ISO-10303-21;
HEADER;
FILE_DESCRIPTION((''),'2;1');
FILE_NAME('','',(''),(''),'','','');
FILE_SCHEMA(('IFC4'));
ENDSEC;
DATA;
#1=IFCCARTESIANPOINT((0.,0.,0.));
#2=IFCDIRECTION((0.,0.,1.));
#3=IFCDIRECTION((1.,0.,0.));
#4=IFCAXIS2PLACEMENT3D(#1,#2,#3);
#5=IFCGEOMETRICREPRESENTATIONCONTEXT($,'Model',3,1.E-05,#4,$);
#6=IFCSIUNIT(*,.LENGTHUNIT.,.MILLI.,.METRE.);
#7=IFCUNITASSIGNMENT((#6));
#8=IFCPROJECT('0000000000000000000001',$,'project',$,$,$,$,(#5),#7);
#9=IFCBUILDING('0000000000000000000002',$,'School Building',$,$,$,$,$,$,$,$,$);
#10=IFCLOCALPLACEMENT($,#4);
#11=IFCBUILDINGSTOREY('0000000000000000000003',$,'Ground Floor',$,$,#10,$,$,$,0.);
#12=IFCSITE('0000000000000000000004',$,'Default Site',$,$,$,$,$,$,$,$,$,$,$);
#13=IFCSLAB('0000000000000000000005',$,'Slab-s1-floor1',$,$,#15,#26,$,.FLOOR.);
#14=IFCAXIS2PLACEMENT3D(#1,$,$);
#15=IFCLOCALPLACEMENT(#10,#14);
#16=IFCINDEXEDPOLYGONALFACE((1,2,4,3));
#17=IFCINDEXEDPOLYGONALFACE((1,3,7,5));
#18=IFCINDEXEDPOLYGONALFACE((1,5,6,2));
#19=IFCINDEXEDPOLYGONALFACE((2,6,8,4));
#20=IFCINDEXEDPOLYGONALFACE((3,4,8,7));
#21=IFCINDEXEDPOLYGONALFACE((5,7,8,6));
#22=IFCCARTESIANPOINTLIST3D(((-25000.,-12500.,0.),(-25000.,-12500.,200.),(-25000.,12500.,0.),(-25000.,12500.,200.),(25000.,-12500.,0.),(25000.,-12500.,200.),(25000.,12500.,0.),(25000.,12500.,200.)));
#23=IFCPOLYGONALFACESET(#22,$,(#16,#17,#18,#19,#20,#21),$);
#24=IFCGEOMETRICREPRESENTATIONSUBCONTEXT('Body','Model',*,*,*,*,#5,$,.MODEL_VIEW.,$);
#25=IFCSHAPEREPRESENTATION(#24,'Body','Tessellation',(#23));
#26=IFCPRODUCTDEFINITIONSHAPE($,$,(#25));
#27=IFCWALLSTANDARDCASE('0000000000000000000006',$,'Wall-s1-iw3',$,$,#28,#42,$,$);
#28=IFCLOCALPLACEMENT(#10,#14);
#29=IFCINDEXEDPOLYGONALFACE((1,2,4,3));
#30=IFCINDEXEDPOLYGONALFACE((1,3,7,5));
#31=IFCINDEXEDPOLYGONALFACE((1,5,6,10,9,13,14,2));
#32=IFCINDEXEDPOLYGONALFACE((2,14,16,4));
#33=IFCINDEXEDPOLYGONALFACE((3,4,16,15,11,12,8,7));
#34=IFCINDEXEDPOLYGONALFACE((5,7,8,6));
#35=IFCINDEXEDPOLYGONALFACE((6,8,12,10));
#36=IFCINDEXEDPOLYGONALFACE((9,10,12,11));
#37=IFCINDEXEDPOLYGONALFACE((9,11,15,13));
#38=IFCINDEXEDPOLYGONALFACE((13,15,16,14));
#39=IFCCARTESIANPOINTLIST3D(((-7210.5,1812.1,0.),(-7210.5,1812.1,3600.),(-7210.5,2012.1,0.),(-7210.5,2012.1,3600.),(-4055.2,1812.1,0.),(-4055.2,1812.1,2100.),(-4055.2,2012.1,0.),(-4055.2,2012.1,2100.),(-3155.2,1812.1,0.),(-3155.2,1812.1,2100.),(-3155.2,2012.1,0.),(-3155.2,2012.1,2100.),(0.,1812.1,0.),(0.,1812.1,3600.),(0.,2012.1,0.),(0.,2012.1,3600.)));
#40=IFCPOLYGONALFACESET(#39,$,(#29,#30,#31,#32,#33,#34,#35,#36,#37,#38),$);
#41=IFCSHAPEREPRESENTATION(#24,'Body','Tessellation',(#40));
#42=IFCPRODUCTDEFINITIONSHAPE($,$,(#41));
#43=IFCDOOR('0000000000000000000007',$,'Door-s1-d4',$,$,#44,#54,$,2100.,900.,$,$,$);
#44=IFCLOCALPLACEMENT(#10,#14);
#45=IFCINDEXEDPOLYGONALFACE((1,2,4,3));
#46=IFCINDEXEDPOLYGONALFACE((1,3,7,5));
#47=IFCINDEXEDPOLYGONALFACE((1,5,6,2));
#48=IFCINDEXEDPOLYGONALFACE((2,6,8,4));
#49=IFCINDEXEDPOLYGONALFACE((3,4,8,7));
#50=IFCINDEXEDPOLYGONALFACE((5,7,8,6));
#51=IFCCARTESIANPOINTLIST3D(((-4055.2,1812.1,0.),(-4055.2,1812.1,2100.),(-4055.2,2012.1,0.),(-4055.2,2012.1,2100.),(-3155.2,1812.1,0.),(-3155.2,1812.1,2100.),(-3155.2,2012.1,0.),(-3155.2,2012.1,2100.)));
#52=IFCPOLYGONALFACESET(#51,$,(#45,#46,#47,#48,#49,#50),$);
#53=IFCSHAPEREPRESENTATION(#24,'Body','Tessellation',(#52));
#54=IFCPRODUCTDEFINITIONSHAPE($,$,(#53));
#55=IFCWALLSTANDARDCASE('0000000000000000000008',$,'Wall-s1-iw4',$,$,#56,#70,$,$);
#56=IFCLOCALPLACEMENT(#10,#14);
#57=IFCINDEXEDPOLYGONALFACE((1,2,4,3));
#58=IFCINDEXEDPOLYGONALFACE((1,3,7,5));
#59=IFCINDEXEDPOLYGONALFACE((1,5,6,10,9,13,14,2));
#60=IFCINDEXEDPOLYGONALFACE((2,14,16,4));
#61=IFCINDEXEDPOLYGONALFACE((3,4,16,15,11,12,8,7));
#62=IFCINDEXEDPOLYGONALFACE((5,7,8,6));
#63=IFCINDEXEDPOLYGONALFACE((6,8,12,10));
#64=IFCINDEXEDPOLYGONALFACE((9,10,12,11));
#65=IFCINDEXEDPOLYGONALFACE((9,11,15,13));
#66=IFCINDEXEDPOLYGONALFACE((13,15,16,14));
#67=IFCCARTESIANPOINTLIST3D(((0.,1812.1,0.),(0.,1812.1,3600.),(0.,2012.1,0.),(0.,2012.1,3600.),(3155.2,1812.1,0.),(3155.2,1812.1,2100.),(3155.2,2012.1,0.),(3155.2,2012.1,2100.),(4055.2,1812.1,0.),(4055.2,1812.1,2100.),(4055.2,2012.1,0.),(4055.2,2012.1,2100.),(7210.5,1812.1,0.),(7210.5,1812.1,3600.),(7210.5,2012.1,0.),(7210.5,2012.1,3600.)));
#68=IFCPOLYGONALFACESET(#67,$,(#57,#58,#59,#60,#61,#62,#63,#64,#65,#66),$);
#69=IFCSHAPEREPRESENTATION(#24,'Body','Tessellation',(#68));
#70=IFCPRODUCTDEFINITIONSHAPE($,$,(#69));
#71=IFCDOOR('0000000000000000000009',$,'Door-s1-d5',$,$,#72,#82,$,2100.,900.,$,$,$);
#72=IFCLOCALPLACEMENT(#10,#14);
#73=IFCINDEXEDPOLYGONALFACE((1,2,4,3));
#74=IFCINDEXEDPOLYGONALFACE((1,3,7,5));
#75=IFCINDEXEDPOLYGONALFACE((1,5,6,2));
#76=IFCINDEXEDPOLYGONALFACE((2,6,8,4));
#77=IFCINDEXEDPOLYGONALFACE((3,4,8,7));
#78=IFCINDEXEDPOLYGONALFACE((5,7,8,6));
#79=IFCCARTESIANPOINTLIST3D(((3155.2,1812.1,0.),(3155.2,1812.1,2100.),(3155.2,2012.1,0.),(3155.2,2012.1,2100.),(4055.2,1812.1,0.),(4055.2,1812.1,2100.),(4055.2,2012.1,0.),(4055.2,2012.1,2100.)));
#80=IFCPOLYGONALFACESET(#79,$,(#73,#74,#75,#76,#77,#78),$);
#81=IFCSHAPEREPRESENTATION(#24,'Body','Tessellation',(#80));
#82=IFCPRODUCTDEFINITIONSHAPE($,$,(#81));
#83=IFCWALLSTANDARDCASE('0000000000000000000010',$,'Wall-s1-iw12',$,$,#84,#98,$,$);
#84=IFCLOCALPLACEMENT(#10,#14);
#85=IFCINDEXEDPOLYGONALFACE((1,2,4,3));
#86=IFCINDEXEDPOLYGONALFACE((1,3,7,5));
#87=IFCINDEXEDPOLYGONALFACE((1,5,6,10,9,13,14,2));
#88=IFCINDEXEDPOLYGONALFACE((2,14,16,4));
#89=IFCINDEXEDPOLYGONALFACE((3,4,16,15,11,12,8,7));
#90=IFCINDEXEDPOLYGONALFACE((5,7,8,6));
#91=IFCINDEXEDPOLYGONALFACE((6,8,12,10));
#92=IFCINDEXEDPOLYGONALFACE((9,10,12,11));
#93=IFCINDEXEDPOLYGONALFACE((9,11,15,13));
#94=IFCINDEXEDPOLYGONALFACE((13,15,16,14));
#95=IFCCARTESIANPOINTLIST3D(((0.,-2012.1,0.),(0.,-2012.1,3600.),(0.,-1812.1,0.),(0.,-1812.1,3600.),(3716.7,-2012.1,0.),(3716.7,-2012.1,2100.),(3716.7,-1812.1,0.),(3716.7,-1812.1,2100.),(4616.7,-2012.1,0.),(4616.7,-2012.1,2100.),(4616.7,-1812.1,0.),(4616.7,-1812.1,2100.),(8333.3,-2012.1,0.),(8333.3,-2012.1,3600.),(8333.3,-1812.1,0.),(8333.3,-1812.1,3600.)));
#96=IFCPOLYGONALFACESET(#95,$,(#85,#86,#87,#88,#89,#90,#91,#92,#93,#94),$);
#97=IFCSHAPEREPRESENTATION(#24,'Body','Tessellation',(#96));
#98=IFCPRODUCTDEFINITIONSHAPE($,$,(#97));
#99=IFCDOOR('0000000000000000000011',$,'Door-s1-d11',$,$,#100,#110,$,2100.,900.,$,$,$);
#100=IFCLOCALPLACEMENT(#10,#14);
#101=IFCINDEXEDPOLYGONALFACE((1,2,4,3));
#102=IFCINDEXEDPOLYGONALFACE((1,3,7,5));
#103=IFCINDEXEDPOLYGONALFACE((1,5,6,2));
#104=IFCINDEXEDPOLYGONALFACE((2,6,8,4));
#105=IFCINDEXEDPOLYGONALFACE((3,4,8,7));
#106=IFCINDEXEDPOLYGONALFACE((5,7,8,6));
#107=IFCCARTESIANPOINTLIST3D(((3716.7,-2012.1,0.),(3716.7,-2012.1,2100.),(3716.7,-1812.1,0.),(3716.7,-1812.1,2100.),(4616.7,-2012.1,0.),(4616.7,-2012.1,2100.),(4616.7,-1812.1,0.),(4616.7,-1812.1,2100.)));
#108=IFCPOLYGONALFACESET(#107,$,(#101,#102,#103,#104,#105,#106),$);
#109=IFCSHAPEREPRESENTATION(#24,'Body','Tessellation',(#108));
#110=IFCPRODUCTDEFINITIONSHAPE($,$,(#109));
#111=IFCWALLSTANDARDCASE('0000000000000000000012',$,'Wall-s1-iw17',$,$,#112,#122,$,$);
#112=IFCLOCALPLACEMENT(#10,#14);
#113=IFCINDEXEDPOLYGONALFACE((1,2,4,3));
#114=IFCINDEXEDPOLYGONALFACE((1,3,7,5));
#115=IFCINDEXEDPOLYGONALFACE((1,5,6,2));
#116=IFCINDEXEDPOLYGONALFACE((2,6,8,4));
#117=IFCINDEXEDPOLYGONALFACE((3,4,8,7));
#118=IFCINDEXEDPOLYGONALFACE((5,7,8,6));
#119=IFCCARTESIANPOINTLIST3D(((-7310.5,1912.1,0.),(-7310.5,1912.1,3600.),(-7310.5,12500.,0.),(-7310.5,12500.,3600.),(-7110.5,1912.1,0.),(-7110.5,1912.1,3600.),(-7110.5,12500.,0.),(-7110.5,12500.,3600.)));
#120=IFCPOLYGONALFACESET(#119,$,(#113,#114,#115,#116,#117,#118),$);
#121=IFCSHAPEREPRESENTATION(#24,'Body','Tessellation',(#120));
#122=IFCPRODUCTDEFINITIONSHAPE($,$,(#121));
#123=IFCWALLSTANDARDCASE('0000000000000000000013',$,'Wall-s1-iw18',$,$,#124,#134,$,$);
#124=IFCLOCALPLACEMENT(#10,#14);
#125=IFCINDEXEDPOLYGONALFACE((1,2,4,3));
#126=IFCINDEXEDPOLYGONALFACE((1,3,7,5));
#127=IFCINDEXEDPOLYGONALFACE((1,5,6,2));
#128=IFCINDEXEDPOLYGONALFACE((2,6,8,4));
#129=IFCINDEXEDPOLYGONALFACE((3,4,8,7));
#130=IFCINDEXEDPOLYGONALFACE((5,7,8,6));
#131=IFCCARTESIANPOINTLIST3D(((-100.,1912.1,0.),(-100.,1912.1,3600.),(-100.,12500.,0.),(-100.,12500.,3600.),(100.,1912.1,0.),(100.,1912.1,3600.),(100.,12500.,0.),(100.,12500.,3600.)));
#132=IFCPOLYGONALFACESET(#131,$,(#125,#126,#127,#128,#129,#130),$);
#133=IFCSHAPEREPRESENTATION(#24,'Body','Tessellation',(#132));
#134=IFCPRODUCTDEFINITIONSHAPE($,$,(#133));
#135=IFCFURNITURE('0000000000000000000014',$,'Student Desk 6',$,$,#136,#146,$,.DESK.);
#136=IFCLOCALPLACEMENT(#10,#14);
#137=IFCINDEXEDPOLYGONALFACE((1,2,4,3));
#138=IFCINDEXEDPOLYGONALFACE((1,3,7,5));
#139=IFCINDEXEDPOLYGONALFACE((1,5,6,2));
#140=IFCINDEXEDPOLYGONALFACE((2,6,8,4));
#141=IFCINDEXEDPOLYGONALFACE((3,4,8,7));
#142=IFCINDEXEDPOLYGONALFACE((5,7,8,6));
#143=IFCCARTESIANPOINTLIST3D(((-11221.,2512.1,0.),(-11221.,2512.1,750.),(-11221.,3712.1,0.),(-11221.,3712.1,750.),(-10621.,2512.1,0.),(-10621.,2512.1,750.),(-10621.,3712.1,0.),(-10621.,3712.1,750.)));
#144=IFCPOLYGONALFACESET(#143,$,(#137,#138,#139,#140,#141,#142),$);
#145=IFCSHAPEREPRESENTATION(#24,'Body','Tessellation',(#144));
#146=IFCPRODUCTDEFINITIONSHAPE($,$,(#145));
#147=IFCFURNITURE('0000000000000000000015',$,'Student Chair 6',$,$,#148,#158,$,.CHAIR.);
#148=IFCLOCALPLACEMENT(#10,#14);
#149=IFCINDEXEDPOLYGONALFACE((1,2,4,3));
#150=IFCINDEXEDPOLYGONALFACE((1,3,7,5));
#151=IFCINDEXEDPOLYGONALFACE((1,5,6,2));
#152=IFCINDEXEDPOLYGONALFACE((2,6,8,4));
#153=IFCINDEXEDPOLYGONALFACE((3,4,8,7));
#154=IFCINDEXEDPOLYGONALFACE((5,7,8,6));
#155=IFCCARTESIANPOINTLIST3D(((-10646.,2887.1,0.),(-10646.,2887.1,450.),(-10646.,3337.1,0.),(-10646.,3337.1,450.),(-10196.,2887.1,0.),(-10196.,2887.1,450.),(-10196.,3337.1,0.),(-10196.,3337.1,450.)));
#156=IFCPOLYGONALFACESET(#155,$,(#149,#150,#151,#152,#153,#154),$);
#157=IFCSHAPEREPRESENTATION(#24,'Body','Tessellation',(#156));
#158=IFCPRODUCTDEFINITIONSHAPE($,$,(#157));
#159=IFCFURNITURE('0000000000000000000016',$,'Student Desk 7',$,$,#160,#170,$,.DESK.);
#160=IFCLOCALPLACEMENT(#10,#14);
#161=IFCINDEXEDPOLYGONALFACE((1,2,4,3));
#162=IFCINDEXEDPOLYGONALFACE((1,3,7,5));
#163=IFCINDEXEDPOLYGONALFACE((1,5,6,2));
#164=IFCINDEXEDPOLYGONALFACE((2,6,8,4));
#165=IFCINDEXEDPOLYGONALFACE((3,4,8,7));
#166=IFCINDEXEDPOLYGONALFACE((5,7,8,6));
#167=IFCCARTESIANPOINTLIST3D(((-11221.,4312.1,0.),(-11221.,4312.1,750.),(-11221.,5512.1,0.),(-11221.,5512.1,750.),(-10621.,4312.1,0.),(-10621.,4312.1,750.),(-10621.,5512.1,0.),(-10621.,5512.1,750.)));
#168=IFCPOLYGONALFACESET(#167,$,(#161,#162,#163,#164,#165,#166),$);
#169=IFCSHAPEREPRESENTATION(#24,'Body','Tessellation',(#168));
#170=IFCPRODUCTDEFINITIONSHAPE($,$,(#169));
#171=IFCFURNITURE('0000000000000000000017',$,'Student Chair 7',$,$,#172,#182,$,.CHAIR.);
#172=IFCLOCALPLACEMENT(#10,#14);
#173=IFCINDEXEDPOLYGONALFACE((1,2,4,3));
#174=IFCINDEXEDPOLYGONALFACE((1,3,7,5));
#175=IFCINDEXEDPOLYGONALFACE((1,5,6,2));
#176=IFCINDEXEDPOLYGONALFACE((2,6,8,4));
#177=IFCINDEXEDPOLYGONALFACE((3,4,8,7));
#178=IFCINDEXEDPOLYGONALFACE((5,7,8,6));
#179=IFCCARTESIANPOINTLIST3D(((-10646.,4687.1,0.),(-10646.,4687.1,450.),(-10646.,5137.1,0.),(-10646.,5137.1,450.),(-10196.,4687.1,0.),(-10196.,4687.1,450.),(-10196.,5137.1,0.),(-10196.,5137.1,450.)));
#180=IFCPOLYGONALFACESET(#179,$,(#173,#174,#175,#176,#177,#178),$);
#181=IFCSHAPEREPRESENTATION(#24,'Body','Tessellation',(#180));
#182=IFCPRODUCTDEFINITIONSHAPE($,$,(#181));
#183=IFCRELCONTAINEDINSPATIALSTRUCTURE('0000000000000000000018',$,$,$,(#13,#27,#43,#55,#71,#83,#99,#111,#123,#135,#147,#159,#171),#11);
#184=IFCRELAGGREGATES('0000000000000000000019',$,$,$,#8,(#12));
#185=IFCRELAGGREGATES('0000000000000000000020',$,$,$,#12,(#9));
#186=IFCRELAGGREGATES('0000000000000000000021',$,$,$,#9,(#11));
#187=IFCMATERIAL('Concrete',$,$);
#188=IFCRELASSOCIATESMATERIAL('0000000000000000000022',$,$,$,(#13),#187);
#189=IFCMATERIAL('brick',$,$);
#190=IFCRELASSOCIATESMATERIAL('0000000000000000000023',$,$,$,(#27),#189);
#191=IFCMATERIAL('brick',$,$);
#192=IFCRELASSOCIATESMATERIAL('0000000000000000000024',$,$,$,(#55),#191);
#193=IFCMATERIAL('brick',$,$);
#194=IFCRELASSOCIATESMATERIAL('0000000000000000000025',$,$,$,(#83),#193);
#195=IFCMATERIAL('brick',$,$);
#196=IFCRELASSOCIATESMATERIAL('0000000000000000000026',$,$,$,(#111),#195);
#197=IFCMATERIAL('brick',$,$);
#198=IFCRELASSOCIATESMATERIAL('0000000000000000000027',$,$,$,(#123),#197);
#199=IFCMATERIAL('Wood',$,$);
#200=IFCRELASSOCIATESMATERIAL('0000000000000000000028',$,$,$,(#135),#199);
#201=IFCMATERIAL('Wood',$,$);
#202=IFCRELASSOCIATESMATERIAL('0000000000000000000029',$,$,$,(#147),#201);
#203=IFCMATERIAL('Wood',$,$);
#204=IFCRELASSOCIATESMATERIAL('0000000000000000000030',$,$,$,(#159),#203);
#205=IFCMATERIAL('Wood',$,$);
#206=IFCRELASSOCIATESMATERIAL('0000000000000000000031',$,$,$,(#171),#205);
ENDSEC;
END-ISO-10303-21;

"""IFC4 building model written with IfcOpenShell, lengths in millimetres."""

from ifc_helpers import new_model, si_unit, frame, frame_2d, origin_with_axes, origin_2d, place, context, subcontext, project, spatial, polyline, rectangle, outline, extrude, material, element, fill, save


model = new_model("IFC4")

# Units and contexts
model_context = context("Model", 3, precision=1e-05, world=origin_with_axes())
body_context = subcontext(model_context, "Body", "Model", "MODEL_VIEW")
ifc_project = project(units=[si_unit("LENGTHUNIT", "METRE", prefix="MILLI")], contexts=[model_context])

# Site, building, storey
site = spatial("IfcSite", under=ifc_project, Name="Default Site")
building = spatial("IfcBuilding", under=site, Name="School Building")
storey_placement = place(None, origin_with_axes())
storey = spatial("IfcBuildingStorey", under=building, at=storey_placement, Name="Ground Floor", Elevation=0.0)

# Slab
ifc_material_1 = material(Name="Concrete")
slab_1_placement = place(storey_placement, origin_with_axes())
element("IfcSlab", 1, at=slab_1_placement, inside=storey, material=ifc_material_1, Name="Slab-s1-floor1", PredefinedType="FLOOR", context=body_context, shape_type="SweptSolid", body=[
    extrude(outline(polyline([(-25000.0, -12500.0), (25000.0, -12500.0), (25000.0, 12500.0), (-25000.0, 12500.0), (-25000.0, -12500.0)])), origin_with_axes(), (0.0, 0.0, 1.0), 200.0),
])

# Walls, openings, doors
ifc_material_2 = material(Name="brick")
wall_1_placement = place(storey_placement, frame((-7210.5, 1912.1, 0.0), z_axis=(0.0, 0.0, 1.0), x_axis=(1.0, 0.0, 0.0)))
wall_1 = element("IfcWallStandardCase", 2, at=wall_1_placement, inside=storey, material=ifc_material_2, Name="Wall-s1-iw3", context=body_context, shape_type="SweptSolid", body=[
    extrude(rectangle(XDim=7210.5, YDim=200.0, at=frame_2d((3605.2, 0.0))), origin_with_axes(), (0.0, 0.0, 1.0), 3600.0),
])
opening_1_placement = place(wall_1_placement, frame((3155.2, 0.0, 0.0), z_axis=(0.0, 0.0, 1.0), x_axis=(1.0, 0.0, 0.0)))
opening_1 = element("IfcOpeningElement", 3, at=opening_1_placement, cuts=wall_1, context=body_context, shape_type="SweptSolid", body=[
    extrude(rectangle(XDim=900.0, YDim=400.0, at=frame_2d((450.0, 0.0))), origin_with_axes(), (0.0, 0.0, 1.0), 2100.0),
])
door_1_placement = place(storey_placement, frame((-4055.2, 1912.1, 0.0), z_axis=(0.0, 0.0, 1.0), x_axis=(1.0, 0.0, 0.0)))
door_1 = element("IfcDoor", 4, at=door_1_placement, inside=storey, Name="Door-s1-d4", OverallHeight=2100.0, OverallWidth=900.0, context=body_context, shape_type="SweptSolid", body=[
    extrude(rectangle(XDim=900.0, YDim=200.0, at=frame_2d((450.0, 0.0))), origin_with_axes(), (0.0, 0.0, 1.0), 2100.0),
])
fill(opening_1, door_1)
ifc_material_3 = material(Name="brick")
wall_2_placement = place(storey_placement, frame((0.0, 1912.1, 0.0), z_axis=(0.0, 0.0, 1.0), x_axis=(1.0, 0.0, 0.0)))
wall_2 = element("IfcWallStandardCase", 5, at=wall_2_placement, inside=storey, material=ifc_material_3, Name="Wall-s1-iw4", context=body_context, shape_type="SweptSolid", body=[
    extrude(rectangle(XDim=7210.5, YDim=200.0, at=frame_2d((3605.2, 0.0))), origin_with_axes(), (0.0, 0.0, 1.0), 3600.0),
])
opening_2_placement = place(wall_2_placement, frame((3155.2, 0.0, 0.0), z_axis=(0.0, 0.0, 1.0), x_axis=(1.0, 0.0, 0.0)))
opening_2 = element("IfcOpeningElement", 6, at=opening_2_placement, cuts=wall_2, context=body_context, shape_type="SweptSolid", body=[
    extrude(rectangle(XDim=900.0, YDim=400.0, at=frame_2d((450.0, 0.0))), origin_with_axes(), (0.0, 0.0, 1.0), 2100.0),
])
door_2_placement = place(storey_placement, frame((3155.2, 1912.1, 0.0), z_axis=(0.0, 0.0, 1.0), x_axis=(1.0, 0.0, 0.0)))
door_2 = element("IfcDoor", 7, at=door_2_placement, inside=storey, Name="Door-s1-d5", OverallHeight=2100.0, OverallWidth=900.0, context=body_context, shape_type="SweptSolid", body=[
    extrude(rectangle(XDim=900.0, YDim=200.0, at=frame_2d((450.0, 0.0))), origin_with_axes(), (0.0, 0.0, 1.0), 2100.0),
])
fill(opening_2, door_2)
ifc_material_4 = material(Name="brick")
wall_3_placement = place(storey_placement, frame((0.0, -1912.1, 0.0), z_axis=(0.0, 0.0, 1.0), x_axis=(1.0, 0.0, 0.0)))
wall_3 = element("IfcWallStandardCase", 8, at=wall_3_placement, inside=storey, material=ifc_material_4, Name="Wall-s1-iw12", context=body_context, shape_type="SweptSolid", body=[
    extrude(rectangle(XDim=8333.3, YDim=200.0, at=frame_2d((4166.7, 0.0))), origin_with_axes(), (0.0, 0.0, 1.0), 3600.0),
])
opening_3_placement = place(wall_3_placement, frame((3716.7, 0.0, 0.0), z_axis=(0.0, 0.0, 1.0), x_axis=(1.0, 0.0, 0.0)))
opening_3 = element("IfcOpeningElement", 9, at=opening_3_placement, cuts=wall_3, context=body_context, shape_type="SweptSolid", body=[
    extrude(rectangle(XDim=900.0, YDim=400.0, at=frame_2d((450.0, 0.0))), origin_with_axes(), (0.0, 0.0, 1.0), 2100.0),
])
door_3_placement = place(storey_placement, frame((3716.7, -1912.1, 0.0), z_axis=(0.0, 0.0, 1.0), x_axis=(1.0, 0.0, 0.0)))
door_3 = element("IfcDoor", 10, at=door_3_placement, inside=storey, Name="Door-s1-d11", OverallHeight=2100.0, OverallWidth=900.0, context=body_context, shape_type="SweptSolid", body=[
    extrude(rectangle(XDim=900.0, YDim=200.0, at=frame_2d((450.0, 0.0))), origin_with_axes(), (0.0, 0.0, 1.0), 2100.0),
])
fill(opening_3, door_3)

# Walls
ifc_material_5 = material(Name="brick")
wall_4_placement = place(storey_placement, frame((-7210.5, 1912.1, 0.0), z_axis=(0.0, 0.0, 1.0), x_axis=(0.0, 1.0, 0.0)))
element("IfcWallStandardCase", 11, at=wall_4_placement, inside=storey, material=ifc_material_5, Name="Wall-s1-iw17", context=body_context, shape_type="SweptSolid", body=[
    extrude(rectangle(XDim=10587.9, YDim=200.0, at=frame_2d((5293.9, 0.0))), origin_with_axes(), (0.0, 0.0, 1.0), 3600.0),
])
ifc_material_6 = material(Name="brick")
wall_5_placement = place(storey_placement, frame((0.0, 1912.1, 0.0), z_axis=(0.0, 0.0, 1.0), x_axis=(0.0, 1.0, 0.0)))
element("IfcWallStandardCase", 12, at=wall_5_placement, inside=storey, material=ifc_material_6, Name="Wall-s1-iw18", context=body_context, shape_type="SweptSolid", body=[
    extrude(rectangle(XDim=10587.9, YDim=200.0, at=frame_2d((5293.9, 0.0))), origin_with_axes(), (0.0, 0.0, 1.0), 3600.0),
])

# Furniture
ifc_material_7 = material(Name="Wood")
furniture_1_placement = place(storey_placement, frame((-10921.0, 3112.1, 0.0), z_axis=(0.0, 0.0, 1.0), x_axis=(0.0, 1.0, 0.0)))
element("IfcFurniture", 13, at=furniture_1_placement, inside=storey, material=ifc_material_7, Name="Student Desk 6", PredefinedType="DESK", context=body_context, shape_type="SweptSolid", body=[
    extrude(rectangle(XDim=1200.0, YDim=600.0, at=origin_2d()), origin_with_axes(), (0.0, 0.0, 1.0), 750.0),
])
ifc_material_8 = material(Name="Wood")
furniture_2_placement = place(storey_placement, frame((-10421.0, 3112.1, 0.0), z_axis=(0.0, 0.0, 1.0), x_axis=(1.0, 0.0, 0.0)))
element("IfcFurniture", 14, at=furniture_2_placement, inside=storey, material=ifc_material_8, Name="Student Chair 6", PredefinedType="CHAIR", context=body_context, shape_type="SweptSolid", body=[
    extrude(rectangle(XDim=450.0, YDim=450.0, at=origin_2d()), origin_with_axes(), (0.0, 0.0, 1.0), 450.0),
])
ifc_material_9 = material(Name="Wood")
furniture_3_placement = place(storey_placement, frame((-10921.0, 4912.1, 0.0), z_axis=(0.0, 0.0, 1.0), x_axis=(0.0, 1.0, 0.0)))
element("IfcFurniture", 15, at=furniture_3_placement, inside=storey, material=ifc_material_9, Name="Student Desk 7", PredefinedType="DESK", context=body_context, shape_type="SweptSolid", body=[
    extrude(rectangle(XDim=1200.0, YDim=600.0, at=origin_2d()), origin_with_axes(), (0.0, 0.0, 1.0), 750.0),
])
ifc_material_10 = material(Name="Wood")
furniture_4_placement = place(storey_placement, frame((-10421.0, 4912.1, 0.0), z_axis=(0.0, 0.0, 1.0), x_axis=(1.0, 0.0, 0.0)))
element("IfcFurniture", 16, at=furniture_4_placement, inside=storey, material=ifc_material_10, Name="Student Chair 7", PredefinedType="CHAIR", context=body_context, shape_type="SweptSolid", body=[
    extrude(rectangle(XDim=450.0, YDim=450.0, at=origin_2d()), origin_with_axes(), (0.0, 0.0, 1.0), 450.0),
])

save(model, "model.ifc")
